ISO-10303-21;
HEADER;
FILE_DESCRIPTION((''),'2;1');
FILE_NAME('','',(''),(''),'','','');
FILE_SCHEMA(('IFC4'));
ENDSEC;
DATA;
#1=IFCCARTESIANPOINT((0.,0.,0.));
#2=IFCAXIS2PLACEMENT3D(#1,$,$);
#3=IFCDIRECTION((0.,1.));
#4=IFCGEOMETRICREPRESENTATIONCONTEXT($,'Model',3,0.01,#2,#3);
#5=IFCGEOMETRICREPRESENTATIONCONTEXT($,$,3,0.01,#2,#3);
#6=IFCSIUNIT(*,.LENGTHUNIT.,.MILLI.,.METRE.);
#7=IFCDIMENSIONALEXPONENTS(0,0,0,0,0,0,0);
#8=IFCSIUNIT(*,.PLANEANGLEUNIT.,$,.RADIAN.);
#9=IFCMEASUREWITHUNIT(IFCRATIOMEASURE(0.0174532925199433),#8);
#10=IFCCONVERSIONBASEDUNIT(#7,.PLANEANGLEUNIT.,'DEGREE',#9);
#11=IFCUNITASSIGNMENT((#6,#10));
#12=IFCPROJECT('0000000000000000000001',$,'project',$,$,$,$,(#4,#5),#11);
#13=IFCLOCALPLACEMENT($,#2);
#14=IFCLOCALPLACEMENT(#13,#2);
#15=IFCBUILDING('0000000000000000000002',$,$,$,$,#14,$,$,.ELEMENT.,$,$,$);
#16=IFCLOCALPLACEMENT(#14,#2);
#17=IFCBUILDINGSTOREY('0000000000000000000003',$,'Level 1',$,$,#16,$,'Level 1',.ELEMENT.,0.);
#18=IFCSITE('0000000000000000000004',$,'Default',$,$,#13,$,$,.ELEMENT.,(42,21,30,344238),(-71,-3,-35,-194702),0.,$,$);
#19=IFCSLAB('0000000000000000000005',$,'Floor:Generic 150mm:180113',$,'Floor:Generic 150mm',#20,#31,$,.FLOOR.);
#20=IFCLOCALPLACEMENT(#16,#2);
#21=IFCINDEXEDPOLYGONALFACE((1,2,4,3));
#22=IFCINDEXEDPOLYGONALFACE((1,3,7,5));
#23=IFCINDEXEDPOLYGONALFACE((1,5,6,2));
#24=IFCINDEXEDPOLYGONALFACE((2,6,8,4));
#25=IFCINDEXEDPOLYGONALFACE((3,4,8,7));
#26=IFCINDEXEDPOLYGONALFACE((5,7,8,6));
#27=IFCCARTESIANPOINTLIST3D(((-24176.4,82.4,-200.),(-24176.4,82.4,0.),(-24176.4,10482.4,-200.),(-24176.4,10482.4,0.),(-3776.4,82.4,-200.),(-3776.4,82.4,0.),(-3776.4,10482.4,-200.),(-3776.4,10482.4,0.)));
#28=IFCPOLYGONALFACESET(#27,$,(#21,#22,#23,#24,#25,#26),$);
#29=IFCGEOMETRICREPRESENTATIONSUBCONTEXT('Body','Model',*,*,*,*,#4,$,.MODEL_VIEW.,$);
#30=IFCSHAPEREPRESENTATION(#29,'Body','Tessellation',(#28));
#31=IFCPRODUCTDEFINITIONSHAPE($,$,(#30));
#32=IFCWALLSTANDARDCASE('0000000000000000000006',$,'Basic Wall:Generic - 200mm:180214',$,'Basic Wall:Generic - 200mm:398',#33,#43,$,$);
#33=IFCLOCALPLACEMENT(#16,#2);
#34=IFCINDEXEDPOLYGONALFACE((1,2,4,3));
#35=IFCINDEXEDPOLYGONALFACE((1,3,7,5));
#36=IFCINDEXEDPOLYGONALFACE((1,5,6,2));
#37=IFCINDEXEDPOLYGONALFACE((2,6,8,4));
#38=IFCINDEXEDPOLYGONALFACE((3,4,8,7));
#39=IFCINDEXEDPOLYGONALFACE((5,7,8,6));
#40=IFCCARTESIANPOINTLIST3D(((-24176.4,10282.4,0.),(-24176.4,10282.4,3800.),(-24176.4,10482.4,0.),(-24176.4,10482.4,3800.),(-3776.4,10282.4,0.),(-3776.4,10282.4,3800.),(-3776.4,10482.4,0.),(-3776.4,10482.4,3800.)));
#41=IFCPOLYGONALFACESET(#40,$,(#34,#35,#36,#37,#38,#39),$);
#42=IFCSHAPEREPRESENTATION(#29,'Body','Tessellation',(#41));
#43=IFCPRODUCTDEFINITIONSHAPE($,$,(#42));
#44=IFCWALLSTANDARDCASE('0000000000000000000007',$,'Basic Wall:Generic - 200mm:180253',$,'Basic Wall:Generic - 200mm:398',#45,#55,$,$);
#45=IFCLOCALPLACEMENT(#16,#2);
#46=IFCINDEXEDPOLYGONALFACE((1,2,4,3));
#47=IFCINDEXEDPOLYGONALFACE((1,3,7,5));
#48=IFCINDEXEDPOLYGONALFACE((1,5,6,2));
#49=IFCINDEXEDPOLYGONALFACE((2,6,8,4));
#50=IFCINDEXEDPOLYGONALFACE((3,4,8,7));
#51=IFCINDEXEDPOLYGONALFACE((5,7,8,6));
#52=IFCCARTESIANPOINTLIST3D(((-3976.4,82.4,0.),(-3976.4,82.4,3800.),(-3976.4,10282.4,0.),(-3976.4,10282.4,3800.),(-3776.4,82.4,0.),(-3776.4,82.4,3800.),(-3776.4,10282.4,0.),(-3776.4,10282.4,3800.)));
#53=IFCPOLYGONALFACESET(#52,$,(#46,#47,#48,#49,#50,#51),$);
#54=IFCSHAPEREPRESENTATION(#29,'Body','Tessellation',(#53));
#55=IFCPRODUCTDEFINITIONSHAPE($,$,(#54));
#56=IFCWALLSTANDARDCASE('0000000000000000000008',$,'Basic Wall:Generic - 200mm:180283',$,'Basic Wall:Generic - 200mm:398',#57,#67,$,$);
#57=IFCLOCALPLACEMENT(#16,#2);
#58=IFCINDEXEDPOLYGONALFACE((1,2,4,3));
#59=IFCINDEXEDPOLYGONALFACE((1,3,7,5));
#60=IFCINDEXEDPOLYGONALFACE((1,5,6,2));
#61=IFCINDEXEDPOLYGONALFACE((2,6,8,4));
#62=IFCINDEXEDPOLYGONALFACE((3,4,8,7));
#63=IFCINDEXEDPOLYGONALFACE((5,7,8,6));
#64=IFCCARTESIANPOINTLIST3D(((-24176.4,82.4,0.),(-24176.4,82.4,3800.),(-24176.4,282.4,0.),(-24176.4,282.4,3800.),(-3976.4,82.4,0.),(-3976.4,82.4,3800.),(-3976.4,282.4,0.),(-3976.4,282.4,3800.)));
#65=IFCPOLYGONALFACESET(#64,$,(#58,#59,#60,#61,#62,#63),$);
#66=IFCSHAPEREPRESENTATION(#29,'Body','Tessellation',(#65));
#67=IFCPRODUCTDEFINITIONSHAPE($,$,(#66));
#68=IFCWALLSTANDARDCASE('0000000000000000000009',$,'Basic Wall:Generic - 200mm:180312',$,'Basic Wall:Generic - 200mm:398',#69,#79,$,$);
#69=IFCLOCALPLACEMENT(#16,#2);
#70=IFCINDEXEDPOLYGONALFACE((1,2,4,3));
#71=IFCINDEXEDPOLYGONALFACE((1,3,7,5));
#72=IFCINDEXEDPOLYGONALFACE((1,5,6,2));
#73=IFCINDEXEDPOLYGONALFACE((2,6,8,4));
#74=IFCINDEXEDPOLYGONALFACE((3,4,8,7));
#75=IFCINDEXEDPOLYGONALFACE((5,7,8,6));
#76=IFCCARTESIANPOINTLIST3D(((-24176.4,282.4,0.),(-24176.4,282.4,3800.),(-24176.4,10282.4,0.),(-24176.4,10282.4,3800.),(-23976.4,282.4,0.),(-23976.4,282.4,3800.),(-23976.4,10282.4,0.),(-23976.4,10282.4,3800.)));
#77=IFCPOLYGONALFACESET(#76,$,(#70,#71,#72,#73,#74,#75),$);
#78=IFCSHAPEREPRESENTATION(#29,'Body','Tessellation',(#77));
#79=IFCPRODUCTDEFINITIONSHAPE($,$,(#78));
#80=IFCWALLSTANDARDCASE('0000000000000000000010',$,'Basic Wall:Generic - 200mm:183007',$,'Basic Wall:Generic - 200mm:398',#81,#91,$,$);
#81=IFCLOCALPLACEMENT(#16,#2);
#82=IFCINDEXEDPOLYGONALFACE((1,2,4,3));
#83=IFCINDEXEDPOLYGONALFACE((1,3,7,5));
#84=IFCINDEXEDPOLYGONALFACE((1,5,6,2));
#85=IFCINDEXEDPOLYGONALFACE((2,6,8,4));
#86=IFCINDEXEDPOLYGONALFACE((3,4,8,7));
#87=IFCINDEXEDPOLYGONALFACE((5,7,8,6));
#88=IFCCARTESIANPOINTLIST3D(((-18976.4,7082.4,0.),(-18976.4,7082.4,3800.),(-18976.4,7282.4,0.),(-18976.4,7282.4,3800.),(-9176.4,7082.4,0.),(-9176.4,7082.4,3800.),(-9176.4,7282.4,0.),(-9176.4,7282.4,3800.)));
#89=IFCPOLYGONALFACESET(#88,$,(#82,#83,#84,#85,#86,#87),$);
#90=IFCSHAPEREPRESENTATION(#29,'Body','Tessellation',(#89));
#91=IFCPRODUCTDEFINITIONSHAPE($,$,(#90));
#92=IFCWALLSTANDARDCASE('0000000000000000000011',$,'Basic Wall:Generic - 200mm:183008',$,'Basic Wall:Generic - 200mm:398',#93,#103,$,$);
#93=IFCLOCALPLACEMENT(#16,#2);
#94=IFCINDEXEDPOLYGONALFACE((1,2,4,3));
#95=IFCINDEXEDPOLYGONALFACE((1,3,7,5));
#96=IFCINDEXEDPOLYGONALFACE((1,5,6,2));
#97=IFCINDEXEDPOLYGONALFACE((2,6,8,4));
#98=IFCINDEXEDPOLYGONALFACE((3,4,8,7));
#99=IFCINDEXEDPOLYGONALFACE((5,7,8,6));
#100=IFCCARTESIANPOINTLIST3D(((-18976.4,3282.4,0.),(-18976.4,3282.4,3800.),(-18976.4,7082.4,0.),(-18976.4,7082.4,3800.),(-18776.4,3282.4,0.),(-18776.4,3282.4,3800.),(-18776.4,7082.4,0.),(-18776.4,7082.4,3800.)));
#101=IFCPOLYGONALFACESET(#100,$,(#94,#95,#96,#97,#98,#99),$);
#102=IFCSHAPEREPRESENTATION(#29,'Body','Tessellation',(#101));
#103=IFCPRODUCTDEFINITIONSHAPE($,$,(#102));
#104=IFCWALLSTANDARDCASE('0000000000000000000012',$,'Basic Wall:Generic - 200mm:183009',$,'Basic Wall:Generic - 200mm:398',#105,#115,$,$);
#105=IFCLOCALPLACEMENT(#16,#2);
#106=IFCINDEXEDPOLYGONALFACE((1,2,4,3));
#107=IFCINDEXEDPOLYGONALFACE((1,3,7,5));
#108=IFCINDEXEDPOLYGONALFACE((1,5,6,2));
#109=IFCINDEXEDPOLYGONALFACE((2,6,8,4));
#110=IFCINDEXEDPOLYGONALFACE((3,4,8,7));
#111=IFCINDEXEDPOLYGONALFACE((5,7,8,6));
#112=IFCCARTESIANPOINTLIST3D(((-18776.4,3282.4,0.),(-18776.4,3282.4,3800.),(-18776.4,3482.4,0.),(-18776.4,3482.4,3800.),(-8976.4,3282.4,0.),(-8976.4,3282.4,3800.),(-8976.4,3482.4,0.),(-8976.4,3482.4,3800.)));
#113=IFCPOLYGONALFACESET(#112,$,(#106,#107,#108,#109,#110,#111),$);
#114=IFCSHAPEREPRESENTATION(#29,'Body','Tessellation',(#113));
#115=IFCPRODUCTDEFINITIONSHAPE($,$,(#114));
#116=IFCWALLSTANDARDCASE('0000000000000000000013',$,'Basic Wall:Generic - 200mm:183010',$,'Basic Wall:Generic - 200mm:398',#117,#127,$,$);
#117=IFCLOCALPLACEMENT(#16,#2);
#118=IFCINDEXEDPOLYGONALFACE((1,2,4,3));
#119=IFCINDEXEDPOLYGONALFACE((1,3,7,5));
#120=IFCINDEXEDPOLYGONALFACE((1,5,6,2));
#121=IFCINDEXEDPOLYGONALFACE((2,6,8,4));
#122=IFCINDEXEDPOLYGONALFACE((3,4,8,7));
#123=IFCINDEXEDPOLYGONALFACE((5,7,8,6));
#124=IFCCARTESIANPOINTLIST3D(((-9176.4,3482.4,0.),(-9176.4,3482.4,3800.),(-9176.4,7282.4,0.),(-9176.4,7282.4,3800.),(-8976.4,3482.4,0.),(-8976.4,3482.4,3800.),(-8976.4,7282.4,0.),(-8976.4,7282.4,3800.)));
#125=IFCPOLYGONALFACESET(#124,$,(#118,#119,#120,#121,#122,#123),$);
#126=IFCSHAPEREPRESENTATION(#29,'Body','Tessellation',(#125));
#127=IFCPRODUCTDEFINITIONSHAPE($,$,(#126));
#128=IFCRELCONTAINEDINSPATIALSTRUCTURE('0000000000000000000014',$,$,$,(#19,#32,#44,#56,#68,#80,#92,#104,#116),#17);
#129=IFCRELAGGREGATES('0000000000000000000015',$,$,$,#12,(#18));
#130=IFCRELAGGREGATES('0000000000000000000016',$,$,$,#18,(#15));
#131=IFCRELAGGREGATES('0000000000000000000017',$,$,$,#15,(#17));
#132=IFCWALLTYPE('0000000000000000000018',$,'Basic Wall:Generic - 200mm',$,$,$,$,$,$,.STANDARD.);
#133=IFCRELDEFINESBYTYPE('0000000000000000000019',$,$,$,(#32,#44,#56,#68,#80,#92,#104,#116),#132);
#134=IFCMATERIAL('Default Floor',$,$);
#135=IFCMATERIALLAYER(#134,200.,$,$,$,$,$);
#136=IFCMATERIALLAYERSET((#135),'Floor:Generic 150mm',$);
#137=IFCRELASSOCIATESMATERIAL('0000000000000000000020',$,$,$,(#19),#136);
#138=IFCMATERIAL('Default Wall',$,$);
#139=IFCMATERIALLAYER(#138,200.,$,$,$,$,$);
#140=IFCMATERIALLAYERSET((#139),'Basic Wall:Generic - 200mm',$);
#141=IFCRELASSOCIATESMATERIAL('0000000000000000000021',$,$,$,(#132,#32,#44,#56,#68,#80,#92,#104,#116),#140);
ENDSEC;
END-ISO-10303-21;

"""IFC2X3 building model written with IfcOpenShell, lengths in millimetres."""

from ifc_helpers import new_model, entity, si_unit, converted_unit, direction, frame, frame_2d, origin, origin_2d_with_axis, place, context, subcontext, project, spatial, rectangle, extrude, material, layer, layer_set, layer_usage, type_object, element, save


model = new_model("IFC2X3")

# Units and contexts
model_context = context("Model", 3, precision=0.01, world=origin(), true_north=direction((0.0, 1.0)))
context_of_model = context(None, 3, precision=0.01, world=origin(), true_north=direction((0.0, 1.0)))
body_context = subcontext(model_context, "Body", "Model", "MODEL_VIEW")
ifc_project = project(units=[si_unit("LENGTHUNIT", "METRE", prefix="MILLI"), converted_unit("PLANEANGLEUNIT", "DEGREE", entity("IfcRatioMeasure", 0.0174532925199433), si_unit("PLANEANGLEUNIT", "RADIAN"), dimensions=[0, 0, 0, 0, 0, 0, 0])], contexts=[model_context, context_of_model])

# Site, building, storey
site_placement = place(None, origin())
site = spatial("IfcSite", under=ifc_project, at=site_placement, Name="Default", CompositionType="ELEMENT", RefLatitude=(42, 21, 30, 344238), RefLongitude=(-71, -3, -35, -194702), RefElevation=0.0)
building_placement = place(site_placement, origin())
building = spatial("IfcBuilding", under=site, at=building_placement, CompositionType="ELEMENT")
storey_placement = place(building_placement, origin())
storey = spatial("IfcBuildingStorey", under=building, at=storey_placement, Name="Level 1", LongName="Level 1", CompositionType="ELEMENT", Elevation=0.0)

# Slab
ifc_material_1 = material(Name="Default Floor")
ifc_layer_1 = layer(ifc_material_1, 200.0)
ifc_layer_set_1 = layer_set([ifc_layer_1], Name="Floor:Generic 150mm")
ifc_layer_usage_1 = layer_usage(ifc_layer_set_1, "AXIS3", "POSITIVE", 0.0)
slab_placement = place(storey_placement, origin())
element("IfcSlab", 1, at=slab_placement, inside=storey, material=ifc_layer_usage_1, Name="Floor:Generic 150mm:180113", ObjectType="Floor:Generic 150mm", PredefinedType="FLOOR", context=body_context, shape_type="SweptSolid", body=[
    extrude(rectangle(XDim=10400.0, YDim=20400.0, at=origin_2d_with_axis()), frame((-13976.4, 5282.4, 0.0), z_axis=(0.0, 0.0, -1.0), x_axis=(0.0, 1.0, 0.0)), (0.0, 0.0, 1.0), 200.0),
])

# Walls
ifc_material_2 = material(Name="Default Wall")
ifc_layer_2 = layer(ifc_material_2, 200.0)
ifc_layer_set_2 = layer_set([ifc_layer_2], Name="Basic Wall:Generic - 200mm")
ifc_layer_usage_2 = layer_usage(ifc_layer_set_2, "AXIS2", "NEGATIVE", 100.0)
wall_type = type_object("IfcWallType", Name="Basic Wall:Generic - 200mm", PredefinedType="STANDARD", material=ifc_layer_set_2)
wall_1_placement = place(storey_placement, frame((-24176.4, 10382.4, 0.0)))
element("IfcWallStandardCase", 2, at=wall_1_placement, inside=storey, type_object=wall_type, material=ifc_layer_usage_2, Name="Basic Wall:Generic - 200mm:180214", ObjectType="Basic Wall:Generic - 200mm:398", context=body_context, shape_type="SweptSolid", body=[
    extrude(rectangle(XDim=20400.0, YDim=200.0, at=frame_2d((10200.0, 0.0), x_axis=(-1.0, 0.0))), origin(), (0.0, 0.0, 1.0), 3800.0),
])
ifc_layer_usage_3 = layer_usage(ifc_layer_set_2, "AXIS2", "NEGATIVE", 100.0)
wall_2_placement = place(storey_placement, frame((-3876.4, 10282.4, 0.0), z_axis=(0.0, 0.0, 1.0), x_axis=(0.0, -1.0, 0.0)))
element("IfcWallStandardCase", 3, at=wall_2_placement, inside=storey, type_object=wall_type, material=ifc_layer_usage_3, Name="Basic Wall:Generic - 200mm:180253", ObjectType="Basic Wall:Generic - 200mm:398", context=body_context, shape_type="SweptSolid", body=[
    extrude(rectangle(XDim=10200.0, YDim=200.0, at=frame_2d((5100.0, 0.0), x_axis=(-1.0, 0.0))), origin(), (0.0, 0.0, 1.0), 3800.0),
])
ifc_layer_usage_4 = layer_usage(ifc_layer_set_2, "AXIS2", "NEGATIVE", 100.0)
wall_3_placement = place(storey_placement, frame((-3976.4, 182.4, 0.0), z_axis=(0.0, 0.0, 1.0), x_axis=(-1.0, 0.0, 0.0)))
element("IfcWallStandardCase", 4, at=wall_3_placement, inside=storey, type_object=wall_type, material=ifc_layer_usage_4, Name="Basic Wall:Generic - 200mm:180283", ObjectType="Basic Wall:Generic - 200mm:398", context=body_context, shape_type="SweptSolid", body=[
    extrude(rectangle(XDim=20200.0, YDim=200.0, at=frame_2d((10100.0, 0.0), x_axis=(-1.0, 0.0))), origin(), (0.0, 0.0, 1.0), 3800.0),
])
ifc_layer_usage_5 = layer_usage(ifc_layer_set_2, "AXIS2", "NEGATIVE", 100.0)
wall_4_placement = place(storey_placement, frame((-24076.4, 282.4, 0.0), z_axis=(0.0, 0.0, 1.0), x_axis=(0.0, 1.0, 0.0)))
element("IfcWallStandardCase", 5, at=wall_4_placement, inside=storey, type_object=wall_type, material=ifc_layer_usage_5, Name="Basic Wall:Generic - 200mm:180312", ObjectType="Basic Wall:Generic - 200mm:398", context=body_context, shape_type="SweptSolid", body=[
    extrude(rectangle(XDim=10000.0, YDim=200.0, at=frame_2d((5000.0, 0.0), x_axis=(-1.0, 0.0))), origin(), (0.0, 0.0, 1.0), 3800.0),
])
ifc_layer_usage_6 = layer_usage(ifc_layer_set_2, "AXIS2", "NEGATIVE", 100.0)
wall_5_placement = place(storey_placement, frame((-18976.4, 7182.4, 0.0)))
element("IfcWallStandardCase", 6, at=wall_5_placement, inside=storey, type_object=wall_type, material=ifc_layer_usage_6, Name="Basic Wall:Generic - 200mm:183007", ObjectType="Basic Wall:Generic - 200mm:398", context=body_context, shape_type="SweptSolid", body=[
    extrude(rectangle(XDim=9800.0, YDim=200.0, at=frame_2d((4900.0, 0.0), x_axis=(-1.0, 0.0))), origin(), (0.0, 0.0, 1.0), 3800.0),
])
ifc_layer_usage_7 = layer_usage(ifc_layer_set_2, "AXIS2", "NEGATIVE", 100.0)
wall_6_placement = place(storey_placement, frame((-18876.4, 3282.4, 0.0), z_axis=(0.0, 0.0, 1.0), x_axis=(0.0, 1.0, 0.0)))
element("IfcWallStandardCase", 7, at=wall_6_placement, inside=storey, type_object=wall_type, material=ifc_layer_usage_7, Name="Basic Wall:Generic - 200mm:183008", ObjectType="Basic Wall:Generic - 200mm:398", context=body_context, shape_type="SweptSolid", body=[
    extrude(rectangle(XDim=3800.0, YDim=200.0, at=frame_2d((1900.0, 0.0), x_axis=(-1.0, 0.0))), origin(), (0.0, 0.0, 1.0), 3800.0),
])
ifc_layer_usage_8 = layer_usage(ifc_layer_set_2, "AXIS2", "NEGATIVE", 100.0)
wall_7_placement = place(storey_placement, frame((-8976.4, 3382.4, 0.0), z_axis=(0.0, 0.0, 1.0), x_axis=(-1.0, 0.0, 0.0)))
element("IfcWallStandardCase", 8, at=wall_7_placement, inside=storey, type_object=wall_type, material=ifc_layer_usage_8, Name="Basic Wall:Generic - 200mm:183009", ObjectType="Basic Wall:Generic - 200mm:398", context=body_context, shape_type="SweptSolid", body=[
    extrude(rectangle(XDim=9800.0, YDim=200.0, at=frame_2d((4900.0, 0.0), x_axis=(-1.0, 0.0))), origin(), (0.0, 0.0, 1.0), 3800.0),
])
ifc_layer_usage_9 = layer_usage(ifc_layer_set_2, "AXIS2", "NEGATIVE", 100.0)
wall_8_placement = place(storey_placement, frame((-9076.4, 7282.4, 0.0), z_axis=(0.0, 0.0, 1.0), x_axis=(0.0, -1.0, 0.0)))
element("IfcWallStandardCase", 9, at=wall_8_placement, inside=storey, type_object=wall_type, material=ifc_layer_usage_9, Name="Basic Wall:Generic - 200mm:183010", ObjectType="Basic Wall:Generic - 200mm:398", context=body_context, shape_type="SweptSolid", body=[
    extrude(rectangle(XDim=3800.0, YDim=200.0, at=frame_2d((1900.0, 0.0), x_axis=(-1.0, 0.0))), origin(), (0.0, 0.0, 1.0), 3800.0),
])

save(model, "model.ifc")
